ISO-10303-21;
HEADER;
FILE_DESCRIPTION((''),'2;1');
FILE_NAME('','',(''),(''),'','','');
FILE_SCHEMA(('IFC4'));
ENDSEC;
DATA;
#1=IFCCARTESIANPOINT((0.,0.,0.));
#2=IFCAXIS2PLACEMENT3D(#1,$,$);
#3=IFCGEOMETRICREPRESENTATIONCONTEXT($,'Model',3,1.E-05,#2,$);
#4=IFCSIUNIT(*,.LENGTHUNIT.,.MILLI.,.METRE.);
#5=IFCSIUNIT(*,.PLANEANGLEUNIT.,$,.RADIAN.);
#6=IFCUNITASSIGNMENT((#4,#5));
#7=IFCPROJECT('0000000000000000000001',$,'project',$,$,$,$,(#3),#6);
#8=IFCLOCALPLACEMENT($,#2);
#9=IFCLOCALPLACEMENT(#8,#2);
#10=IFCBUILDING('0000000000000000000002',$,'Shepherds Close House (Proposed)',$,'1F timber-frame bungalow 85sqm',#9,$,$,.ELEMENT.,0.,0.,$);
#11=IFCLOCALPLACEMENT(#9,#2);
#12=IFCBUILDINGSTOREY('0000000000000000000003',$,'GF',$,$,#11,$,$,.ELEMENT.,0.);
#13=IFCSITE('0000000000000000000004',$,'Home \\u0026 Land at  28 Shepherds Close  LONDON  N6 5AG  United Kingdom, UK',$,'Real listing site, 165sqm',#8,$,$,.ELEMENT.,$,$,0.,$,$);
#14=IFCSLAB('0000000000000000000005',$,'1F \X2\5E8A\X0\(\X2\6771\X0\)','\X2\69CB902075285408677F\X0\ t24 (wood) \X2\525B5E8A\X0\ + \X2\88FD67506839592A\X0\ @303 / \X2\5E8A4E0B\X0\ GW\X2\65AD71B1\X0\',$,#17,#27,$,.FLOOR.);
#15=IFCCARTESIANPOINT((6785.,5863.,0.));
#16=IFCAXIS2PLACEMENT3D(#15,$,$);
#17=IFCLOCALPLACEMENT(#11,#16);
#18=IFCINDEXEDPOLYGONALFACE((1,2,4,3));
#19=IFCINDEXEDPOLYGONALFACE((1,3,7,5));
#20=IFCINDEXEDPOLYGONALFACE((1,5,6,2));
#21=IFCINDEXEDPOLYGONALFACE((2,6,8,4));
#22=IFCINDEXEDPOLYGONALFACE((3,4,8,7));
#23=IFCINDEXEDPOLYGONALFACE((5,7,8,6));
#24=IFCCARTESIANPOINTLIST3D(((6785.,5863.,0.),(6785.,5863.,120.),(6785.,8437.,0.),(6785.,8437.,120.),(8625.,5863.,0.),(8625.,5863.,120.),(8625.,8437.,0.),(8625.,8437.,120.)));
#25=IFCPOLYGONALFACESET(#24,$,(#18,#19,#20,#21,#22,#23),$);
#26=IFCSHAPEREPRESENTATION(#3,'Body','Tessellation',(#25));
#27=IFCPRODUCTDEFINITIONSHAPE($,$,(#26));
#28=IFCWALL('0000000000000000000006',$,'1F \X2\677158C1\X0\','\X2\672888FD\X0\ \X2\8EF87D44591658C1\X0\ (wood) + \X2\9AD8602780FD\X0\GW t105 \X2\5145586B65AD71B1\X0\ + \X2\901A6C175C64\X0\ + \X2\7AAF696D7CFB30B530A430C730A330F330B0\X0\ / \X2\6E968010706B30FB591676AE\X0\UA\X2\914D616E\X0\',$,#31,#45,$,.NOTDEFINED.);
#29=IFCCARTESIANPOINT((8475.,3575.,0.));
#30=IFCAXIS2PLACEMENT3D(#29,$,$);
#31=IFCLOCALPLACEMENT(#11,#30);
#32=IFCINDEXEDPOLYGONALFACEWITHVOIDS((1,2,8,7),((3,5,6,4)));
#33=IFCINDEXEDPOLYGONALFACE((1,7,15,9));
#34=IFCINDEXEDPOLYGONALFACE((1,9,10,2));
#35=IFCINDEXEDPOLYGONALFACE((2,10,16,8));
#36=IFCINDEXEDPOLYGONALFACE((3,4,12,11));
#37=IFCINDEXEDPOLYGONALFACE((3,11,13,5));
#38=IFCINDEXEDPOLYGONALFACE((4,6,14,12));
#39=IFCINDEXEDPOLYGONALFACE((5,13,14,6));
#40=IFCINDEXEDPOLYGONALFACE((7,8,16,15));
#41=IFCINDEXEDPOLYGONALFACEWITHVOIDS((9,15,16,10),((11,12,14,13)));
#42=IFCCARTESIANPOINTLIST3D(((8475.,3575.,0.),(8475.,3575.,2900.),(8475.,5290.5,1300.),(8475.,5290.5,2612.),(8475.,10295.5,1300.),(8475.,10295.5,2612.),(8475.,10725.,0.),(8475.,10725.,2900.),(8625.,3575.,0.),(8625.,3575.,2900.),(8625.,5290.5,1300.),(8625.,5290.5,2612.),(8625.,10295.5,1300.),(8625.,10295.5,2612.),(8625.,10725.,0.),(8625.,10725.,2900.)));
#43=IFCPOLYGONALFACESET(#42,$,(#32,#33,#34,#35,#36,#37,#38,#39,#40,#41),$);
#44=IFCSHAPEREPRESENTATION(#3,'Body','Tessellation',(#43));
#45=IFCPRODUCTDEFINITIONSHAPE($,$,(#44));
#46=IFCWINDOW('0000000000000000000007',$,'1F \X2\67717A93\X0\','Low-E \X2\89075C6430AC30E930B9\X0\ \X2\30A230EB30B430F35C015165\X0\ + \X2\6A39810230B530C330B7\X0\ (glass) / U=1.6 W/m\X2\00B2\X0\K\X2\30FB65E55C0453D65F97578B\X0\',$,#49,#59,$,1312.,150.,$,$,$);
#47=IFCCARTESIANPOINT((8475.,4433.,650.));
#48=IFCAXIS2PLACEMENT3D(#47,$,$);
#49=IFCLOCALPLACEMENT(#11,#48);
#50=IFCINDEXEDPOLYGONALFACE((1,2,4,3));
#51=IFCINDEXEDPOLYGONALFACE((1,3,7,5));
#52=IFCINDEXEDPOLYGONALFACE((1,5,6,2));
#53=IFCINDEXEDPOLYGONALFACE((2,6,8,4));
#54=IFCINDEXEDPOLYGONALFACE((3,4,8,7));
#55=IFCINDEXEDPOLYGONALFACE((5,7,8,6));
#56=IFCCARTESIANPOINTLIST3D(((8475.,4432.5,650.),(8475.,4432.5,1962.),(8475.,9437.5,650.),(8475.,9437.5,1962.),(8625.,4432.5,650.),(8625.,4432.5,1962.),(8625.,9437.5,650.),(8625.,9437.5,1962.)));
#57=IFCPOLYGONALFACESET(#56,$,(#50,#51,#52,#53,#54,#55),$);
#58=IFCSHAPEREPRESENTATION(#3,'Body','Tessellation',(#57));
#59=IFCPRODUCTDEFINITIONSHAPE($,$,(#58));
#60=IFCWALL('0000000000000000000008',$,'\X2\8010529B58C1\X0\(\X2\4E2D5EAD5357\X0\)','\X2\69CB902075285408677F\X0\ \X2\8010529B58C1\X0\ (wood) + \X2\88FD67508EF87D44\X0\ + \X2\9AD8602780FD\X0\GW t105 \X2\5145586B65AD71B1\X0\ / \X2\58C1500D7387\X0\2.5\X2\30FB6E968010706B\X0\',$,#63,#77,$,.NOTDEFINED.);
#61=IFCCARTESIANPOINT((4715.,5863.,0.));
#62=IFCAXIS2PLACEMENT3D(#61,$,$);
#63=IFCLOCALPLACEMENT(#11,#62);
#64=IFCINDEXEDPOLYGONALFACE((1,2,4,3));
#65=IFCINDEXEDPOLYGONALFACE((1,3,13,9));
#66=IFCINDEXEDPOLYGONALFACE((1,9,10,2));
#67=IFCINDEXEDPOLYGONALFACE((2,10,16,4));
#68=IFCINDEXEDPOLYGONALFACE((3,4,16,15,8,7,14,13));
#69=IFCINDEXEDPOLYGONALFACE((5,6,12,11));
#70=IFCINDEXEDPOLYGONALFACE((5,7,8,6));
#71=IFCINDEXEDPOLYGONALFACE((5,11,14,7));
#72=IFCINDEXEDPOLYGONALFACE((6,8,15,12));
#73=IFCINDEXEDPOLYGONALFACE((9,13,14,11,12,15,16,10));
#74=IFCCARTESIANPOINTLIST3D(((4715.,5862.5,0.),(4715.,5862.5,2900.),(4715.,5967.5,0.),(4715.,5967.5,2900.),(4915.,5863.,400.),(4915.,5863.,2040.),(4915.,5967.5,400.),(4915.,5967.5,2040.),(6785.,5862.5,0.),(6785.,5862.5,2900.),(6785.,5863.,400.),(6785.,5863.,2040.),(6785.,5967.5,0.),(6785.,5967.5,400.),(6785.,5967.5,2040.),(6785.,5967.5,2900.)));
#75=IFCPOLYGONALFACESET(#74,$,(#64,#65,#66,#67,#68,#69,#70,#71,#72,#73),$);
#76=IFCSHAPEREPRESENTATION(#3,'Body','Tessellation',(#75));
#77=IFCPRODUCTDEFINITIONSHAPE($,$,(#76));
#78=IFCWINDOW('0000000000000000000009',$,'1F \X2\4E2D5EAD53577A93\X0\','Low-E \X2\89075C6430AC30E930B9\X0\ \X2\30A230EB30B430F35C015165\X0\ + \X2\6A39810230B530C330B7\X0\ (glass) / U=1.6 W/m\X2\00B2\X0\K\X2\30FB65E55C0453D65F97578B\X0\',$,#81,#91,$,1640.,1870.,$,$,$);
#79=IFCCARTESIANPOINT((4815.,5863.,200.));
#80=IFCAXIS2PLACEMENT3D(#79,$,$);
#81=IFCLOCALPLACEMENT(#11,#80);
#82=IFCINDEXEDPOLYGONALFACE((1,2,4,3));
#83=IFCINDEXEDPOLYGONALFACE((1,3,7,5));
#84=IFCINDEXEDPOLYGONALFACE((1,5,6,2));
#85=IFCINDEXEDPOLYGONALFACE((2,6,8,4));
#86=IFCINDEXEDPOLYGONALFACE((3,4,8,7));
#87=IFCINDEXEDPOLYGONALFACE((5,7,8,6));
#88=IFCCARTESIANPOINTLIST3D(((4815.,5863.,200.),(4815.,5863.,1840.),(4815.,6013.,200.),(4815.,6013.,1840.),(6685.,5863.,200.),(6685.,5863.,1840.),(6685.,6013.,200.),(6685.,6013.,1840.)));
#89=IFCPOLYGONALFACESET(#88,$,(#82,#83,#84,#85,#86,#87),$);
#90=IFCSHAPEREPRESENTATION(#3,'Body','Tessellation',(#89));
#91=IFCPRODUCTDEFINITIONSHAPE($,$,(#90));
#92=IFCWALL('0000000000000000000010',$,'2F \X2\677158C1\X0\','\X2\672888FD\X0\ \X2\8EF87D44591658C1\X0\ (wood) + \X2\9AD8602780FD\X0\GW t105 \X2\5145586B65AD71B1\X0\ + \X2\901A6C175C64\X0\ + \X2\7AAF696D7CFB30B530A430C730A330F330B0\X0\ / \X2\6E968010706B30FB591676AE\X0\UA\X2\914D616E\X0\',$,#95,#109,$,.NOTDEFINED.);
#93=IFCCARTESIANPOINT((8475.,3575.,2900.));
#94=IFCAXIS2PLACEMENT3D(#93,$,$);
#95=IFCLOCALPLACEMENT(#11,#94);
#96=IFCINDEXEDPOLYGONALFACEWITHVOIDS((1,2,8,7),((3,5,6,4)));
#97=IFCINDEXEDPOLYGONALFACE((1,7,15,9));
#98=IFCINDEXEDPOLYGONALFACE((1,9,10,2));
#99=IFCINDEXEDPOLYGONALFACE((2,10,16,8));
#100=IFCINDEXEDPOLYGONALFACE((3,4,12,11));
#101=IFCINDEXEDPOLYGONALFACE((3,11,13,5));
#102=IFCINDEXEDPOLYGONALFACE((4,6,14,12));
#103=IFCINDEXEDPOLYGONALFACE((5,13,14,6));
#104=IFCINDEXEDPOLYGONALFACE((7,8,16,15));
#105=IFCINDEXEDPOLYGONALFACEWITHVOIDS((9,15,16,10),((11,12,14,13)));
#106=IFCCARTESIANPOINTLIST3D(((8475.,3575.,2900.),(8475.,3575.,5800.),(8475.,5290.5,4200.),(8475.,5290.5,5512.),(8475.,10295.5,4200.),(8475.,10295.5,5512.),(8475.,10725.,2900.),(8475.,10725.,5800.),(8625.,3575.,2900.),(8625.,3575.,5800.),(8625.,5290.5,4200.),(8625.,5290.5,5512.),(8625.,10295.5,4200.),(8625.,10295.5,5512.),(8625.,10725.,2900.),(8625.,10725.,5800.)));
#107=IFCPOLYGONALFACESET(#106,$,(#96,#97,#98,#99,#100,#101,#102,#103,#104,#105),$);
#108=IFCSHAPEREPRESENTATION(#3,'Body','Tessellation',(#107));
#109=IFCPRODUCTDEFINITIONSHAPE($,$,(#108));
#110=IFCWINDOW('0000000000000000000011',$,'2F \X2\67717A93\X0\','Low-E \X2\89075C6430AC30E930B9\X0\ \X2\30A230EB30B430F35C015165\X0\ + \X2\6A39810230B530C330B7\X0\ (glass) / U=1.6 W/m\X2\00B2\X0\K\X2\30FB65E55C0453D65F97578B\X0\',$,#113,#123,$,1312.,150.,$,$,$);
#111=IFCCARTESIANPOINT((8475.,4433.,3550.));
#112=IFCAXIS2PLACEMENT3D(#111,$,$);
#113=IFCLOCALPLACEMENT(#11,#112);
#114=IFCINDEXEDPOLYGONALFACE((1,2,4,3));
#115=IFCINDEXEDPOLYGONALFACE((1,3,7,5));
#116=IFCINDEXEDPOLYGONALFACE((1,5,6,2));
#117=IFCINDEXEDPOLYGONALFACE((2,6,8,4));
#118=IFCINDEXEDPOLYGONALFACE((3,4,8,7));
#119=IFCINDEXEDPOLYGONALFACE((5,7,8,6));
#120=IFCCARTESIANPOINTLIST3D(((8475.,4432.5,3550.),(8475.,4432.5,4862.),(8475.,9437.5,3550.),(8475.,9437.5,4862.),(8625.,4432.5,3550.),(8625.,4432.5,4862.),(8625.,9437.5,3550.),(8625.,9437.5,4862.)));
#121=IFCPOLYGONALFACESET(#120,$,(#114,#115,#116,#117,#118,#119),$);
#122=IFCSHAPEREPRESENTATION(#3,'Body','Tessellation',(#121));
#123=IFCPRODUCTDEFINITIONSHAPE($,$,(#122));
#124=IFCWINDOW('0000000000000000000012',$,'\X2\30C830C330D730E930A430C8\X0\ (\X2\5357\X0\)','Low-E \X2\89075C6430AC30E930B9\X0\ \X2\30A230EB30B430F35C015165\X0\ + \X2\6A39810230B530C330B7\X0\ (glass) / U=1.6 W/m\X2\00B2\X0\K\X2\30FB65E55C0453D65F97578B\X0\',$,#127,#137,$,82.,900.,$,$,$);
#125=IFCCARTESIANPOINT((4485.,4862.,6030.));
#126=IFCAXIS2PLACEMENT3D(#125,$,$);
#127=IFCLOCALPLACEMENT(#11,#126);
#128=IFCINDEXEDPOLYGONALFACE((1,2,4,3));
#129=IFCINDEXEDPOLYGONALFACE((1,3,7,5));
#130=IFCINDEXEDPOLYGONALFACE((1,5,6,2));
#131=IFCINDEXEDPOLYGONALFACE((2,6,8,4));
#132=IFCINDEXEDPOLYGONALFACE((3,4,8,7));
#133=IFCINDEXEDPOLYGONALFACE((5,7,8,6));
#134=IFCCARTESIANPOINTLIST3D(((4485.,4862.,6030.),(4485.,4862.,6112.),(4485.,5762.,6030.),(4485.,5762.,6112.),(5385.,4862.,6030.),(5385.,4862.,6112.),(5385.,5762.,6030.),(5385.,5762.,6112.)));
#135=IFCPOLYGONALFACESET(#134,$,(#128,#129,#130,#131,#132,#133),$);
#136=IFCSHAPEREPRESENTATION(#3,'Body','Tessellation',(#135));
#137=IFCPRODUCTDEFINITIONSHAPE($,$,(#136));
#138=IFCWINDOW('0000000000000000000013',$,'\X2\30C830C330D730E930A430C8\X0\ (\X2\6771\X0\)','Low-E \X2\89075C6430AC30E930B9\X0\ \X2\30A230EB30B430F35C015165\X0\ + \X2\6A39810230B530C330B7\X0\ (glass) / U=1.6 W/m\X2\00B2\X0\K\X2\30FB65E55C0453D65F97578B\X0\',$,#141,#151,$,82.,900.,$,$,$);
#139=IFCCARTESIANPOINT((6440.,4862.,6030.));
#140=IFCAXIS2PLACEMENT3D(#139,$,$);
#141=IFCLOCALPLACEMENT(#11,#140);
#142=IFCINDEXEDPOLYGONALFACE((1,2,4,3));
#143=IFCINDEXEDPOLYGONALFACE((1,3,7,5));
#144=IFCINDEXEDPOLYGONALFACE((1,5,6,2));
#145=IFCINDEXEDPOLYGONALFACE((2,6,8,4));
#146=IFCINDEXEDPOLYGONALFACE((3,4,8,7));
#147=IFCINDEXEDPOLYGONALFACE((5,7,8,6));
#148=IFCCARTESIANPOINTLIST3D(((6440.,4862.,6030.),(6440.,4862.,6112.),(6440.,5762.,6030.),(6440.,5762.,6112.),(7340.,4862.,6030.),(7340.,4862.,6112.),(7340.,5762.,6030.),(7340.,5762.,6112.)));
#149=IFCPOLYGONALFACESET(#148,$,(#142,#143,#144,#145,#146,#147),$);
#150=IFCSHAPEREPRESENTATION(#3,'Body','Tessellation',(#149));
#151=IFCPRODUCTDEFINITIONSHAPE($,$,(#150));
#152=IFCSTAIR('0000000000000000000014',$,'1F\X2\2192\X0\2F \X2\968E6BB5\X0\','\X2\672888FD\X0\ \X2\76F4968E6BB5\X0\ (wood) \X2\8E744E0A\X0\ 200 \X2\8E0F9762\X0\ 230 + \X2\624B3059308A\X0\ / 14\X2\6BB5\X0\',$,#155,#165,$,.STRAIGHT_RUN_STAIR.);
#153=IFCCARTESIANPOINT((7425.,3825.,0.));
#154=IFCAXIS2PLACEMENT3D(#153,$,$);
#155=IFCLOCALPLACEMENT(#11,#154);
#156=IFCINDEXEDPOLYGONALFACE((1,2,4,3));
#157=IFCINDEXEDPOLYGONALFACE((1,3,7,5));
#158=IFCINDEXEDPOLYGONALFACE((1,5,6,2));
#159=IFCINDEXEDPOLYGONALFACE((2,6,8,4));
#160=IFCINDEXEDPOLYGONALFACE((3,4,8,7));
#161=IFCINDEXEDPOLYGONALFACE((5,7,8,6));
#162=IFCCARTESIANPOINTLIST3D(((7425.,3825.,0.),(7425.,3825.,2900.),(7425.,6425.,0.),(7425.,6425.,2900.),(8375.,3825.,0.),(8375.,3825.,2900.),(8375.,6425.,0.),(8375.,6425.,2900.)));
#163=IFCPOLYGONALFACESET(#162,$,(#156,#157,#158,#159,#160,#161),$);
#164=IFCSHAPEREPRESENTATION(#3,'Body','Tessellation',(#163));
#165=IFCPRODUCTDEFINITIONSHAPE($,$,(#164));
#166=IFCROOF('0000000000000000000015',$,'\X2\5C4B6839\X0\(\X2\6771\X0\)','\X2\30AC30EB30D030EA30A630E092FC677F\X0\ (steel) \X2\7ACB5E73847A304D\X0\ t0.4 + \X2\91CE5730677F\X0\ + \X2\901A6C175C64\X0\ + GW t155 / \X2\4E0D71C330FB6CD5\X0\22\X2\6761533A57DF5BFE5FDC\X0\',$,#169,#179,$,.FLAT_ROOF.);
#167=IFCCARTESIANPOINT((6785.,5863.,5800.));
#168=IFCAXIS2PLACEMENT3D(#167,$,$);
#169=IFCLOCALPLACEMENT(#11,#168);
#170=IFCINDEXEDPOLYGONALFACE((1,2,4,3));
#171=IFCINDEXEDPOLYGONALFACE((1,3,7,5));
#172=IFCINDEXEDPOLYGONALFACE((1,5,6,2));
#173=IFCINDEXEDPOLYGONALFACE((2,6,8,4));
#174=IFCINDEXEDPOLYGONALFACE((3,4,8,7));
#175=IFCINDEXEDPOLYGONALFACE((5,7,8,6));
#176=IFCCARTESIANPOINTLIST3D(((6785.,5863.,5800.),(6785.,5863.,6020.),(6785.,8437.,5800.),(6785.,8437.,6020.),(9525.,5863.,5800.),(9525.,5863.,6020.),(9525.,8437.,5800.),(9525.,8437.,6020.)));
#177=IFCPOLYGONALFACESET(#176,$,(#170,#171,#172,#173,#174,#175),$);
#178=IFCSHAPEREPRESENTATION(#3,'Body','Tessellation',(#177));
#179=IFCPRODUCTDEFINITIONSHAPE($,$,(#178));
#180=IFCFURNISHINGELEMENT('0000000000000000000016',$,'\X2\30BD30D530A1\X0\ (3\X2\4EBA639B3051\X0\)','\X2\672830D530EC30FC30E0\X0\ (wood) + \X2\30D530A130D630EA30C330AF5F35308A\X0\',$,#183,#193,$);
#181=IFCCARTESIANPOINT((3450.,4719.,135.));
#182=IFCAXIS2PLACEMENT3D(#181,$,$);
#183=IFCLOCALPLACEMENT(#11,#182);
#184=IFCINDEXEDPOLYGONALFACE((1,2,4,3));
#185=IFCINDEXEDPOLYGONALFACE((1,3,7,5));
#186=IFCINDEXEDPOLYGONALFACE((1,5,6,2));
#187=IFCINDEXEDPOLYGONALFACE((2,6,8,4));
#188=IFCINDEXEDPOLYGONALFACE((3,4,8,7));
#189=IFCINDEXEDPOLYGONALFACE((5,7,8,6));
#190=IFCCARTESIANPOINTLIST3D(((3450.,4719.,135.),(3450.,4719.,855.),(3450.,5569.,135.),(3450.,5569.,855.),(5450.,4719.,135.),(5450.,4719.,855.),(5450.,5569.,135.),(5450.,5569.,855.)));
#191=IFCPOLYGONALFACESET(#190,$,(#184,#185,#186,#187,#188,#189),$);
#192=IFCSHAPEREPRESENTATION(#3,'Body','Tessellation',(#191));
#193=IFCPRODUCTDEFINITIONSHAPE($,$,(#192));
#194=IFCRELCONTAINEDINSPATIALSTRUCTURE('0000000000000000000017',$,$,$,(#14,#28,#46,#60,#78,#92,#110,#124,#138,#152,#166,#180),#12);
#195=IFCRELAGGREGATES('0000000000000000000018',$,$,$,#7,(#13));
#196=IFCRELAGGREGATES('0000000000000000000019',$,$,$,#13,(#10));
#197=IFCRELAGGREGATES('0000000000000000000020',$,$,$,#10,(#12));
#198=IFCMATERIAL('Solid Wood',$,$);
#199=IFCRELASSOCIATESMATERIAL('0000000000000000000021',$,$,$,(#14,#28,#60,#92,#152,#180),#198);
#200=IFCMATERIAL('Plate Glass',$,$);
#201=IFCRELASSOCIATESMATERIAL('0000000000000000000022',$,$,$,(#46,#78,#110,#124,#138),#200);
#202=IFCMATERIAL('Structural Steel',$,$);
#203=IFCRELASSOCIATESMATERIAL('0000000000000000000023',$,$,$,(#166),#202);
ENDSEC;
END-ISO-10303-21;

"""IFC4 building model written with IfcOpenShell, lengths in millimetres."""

from ifc_helpers import new_model, si_unit, frame, frame_2d, origin, place, context, project, spatial, rectangle, extrude, material, element, fill, save


model = new_model("IFC4")

# Units and contexts
model_context = context("Model", 3, precision=1e-05, world=origin())
ifc_project = project(units=[si_unit("LENGTHUNIT", "METRE", prefix="MILLI"), si_unit("PLANEANGLEUNIT", "RADIAN")], contexts=[model_context])

# Site, building, storey
site_placement = place(None, origin())
site = spatial("IfcSite", under=ifc_project, at=site_placement, Name="Home \\u0026 Land at  28 Shepherds Close  LONDON  N6 5AG  United Kingdom, UK", ObjectType="Real listing site, 165sqm", CompositionType="ELEMENT", RefElevation=0.0)
building_placement = place(site_placement, origin())
building = spatial("IfcBuilding", under=site, at=building_placement, Name="Shepherds Close House (Proposed)", ObjectType="1F timber-frame bungalow 85sqm", CompositionType="ELEMENT", ElevationOfRefHeight=0.0, ElevationOfTerrain=0.0)
storey_placement = place(building_placement, origin())
storey = spatial("IfcBuildingStorey", under=building, at=storey_placement, Name="GF", CompositionType="ELEMENT", Elevation=0.0)

# Slab
ifc_material_1 = material(Name="Solid Wood")
slab_placement = place(storey_placement, frame((6785.0, 5863.0, 0.0)))
element("IfcSlab", 1, at=slab_placement, inside=storey, material=ifc_material_1, Name="1F 床(東)", Description="構造用合板 t24 (wood) 剛床 + 製材根太 @303 / 床下 GW断熱", PredefinedType="FLOOR", context=model_context, shape_type="SweptSolid", body=[
    extrude(rectangle(XDim=1840.0, YDim=2574.0, at=frame_2d((920.0, 1287.0))), frame((6785.0, 5863.0, 0.0)), (0.0, 0.0, 1.0), 120.0),
])

# Walls, openings, windows
wall_1_placement = place(storey_placement, frame((8475.0, 3575.0, 0.0)))
wall_1 = element("IfcWall", 2, at=wall_1_placement, inside=storey, material=ifc_material_1, Name="1F 東壁", Description="木製 軸組外壁 (wood) + 高性能GW t105 充填断熱 + 通気層 + 窯業系サイディング / 準耐火・外皮UA配慮", PredefinedType="NOTDEFINED", context=model_context, shape_type="SweptSolid", body=[
    extrude(rectangle(XDim=150.0, YDim=7150.0, at=frame_2d((75.0, 3575.0))), frame((8475.0, 3575.0, 0.0)), (0.0, 0.0, 1.0), 2900.0),
])
opening_1_placement = place(storey_placement, frame((8475.0, 4433.0, 650.0)))
opening_1 = element("IfcOpeningElement", 3, at=opening_1_placement, cuts=wall_1, PredefinedType="NOTDEFINED", context=model_context, shape_type="SweptSolid", body=[
    extrude(rectangle(XDim=150.0, YDim=5005.0, at=frame_2d((75.0, 2502.0))), frame((8475.0, 4433.0, 650.0)), (0.0, 0.0, 1.0), 1312.0),
])
ifc_material_2 = material(Name="Plate Glass")
window_1_placement = place(storey_placement, frame((8475.0, 4433.0, 650.0)))
window_1 = element("IfcWindow", 4, at=window_1_placement, inside=storey, material=ifc_material_2, Name="1F 東窓", Description="Low-E 複層ガラス アルゴン封入 + 樹脂サッシ (glass) / U=1.6 W/m²K・日射取得型", OverallHeight=1312.0, OverallWidth=150.0, context=model_context, shape_type="SweptSolid", body=[
    extrude(rectangle(XDim=150.0, YDim=5005.0, at=frame_2d((75.0, 2502.0))), frame((8475.0, 4433.0, 650.0)), (0.0, 0.0, 1.0), 1312.0),
])
fill(opening_1, window_1)
wall_2_placement = place(storey_placement, frame((4715.0, 5863.0, 0.0)))
wall_2 = element("IfcWall", 5, at=wall_2_placement, inside=storey, material=ifc_material_1, Name="耐力壁(中庭南)", Description="構造用合板 耐力壁 (wood) + 製材軸組 + 高性能GW t105 充填断熱 / 壁倍率2.5・準耐火", PredefinedType="NOTDEFINED", context=model_context, shape_type="SweptSolid", body=[
    extrude(rectangle(XDim=2070.0, YDim=105.0, at=frame_2d((1035.0, 52.0))), frame((4715.0, 5863.0, 0.0)), (0.0, 0.0, 1.0), 2900.0),
])
opening_2_placement = place(storey_placement, frame((4815.0, 5863.0, 200.0)))
opening_2 = element("IfcOpeningElement", 6, at=opening_2_placement, cuts=wall_2, PredefinedType="NOTDEFINED", context=model_context, shape_type="SweptSolid", body=[
    extrude(rectangle(XDim=1870.0, YDim=150.0, at=frame_2d((935.0, 75.0))), frame((4815.0, 5863.0, 200.0)), (0.0, 0.0, 1.0), 1640.0),
])
window_2_placement = place(storey_placement, frame((4815.0, 5863.0, 200.0)))
window_2 = element("IfcWindow", 7, at=window_2_placement, inside=storey, material=ifc_material_2, Name="1F 中庭南窓", Description="Low-E 複層ガラス アルゴン封入 + 樹脂サッシ (glass) / U=1.6 W/m²K・日射取得型", OverallHeight=1640.0, OverallWidth=1870.0, context=model_context, shape_type="SweptSolid", body=[
    extrude(rectangle(XDim=1870.0, YDim=150.0, at=frame_2d((935.0, 75.0))), frame((4815.0, 5863.0, 200.0)), (0.0, 0.0, 1.0), 1640.0),
])
fill(opening_2, window_2)

# Wall, opening, window
wall_3_placement = place(storey_placement, frame((8475.0, 3575.0, 2900.0)))
wall_3 = element("IfcWall", 8, at=wall_3_placement, inside=storey, material=ifc_material_1, Name="2F 東壁", Description="木製 軸組外壁 (wood) + 高性能GW t105 充填断熱 + 通気層 + 窯業系サイディング / 準耐火・外皮UA配慮", PredefinedType="NOTDEFINED", context=model_context, shape_type="SweptSolid", body=[
    extrude(rectangle(XDim=150.0, YDim=7150.0, at=frame_2d((75.0, 3575.0))), frame((8475.0, 3575.0, 2900.0)), (0.0, 0.0, 1.0), 2900.0),
])
opening_3_placement = place(storey_placement, frame((8475.0, 4433.0, 3550.0)))
opening_3 = element("IfcOpeningElement", 9, at=opening_3_placement, cuts=wall_3, PredefinedType="NOTDEFINED", context=model_context, shape_type="SweptSolid", body=[
    extrude(rectangle(XDim=150.0, YDim=5005.0, at=frame_2d((75.0, 2502.0))), frame((8475.0, 4433.0, 3550.0)), (0.0, 0.0, 1.0), 1312.0),
])
window_3_placement = place(storey_placement, frame((8475.0, 4433.0, 3550.0)))
window_3 = element("IfcWindow", 10, at=window_3_placement, inside=storey, material=ifc_material_2, Name="2F 東窓", Description="Low-E 複層ガラス アルゴン封入 + 樹脂サッシ (glass) / U=1.6 W/m²K・日射取得型", OverallHeight=1312.0, OverallWidth=150.0, context=model_context, shape_type="SweptSolid", body=[
    extrude(rectangle(XDim=150.0, YDim=5005.0, at=frame_2d((75.0, 2502.0))), frame((8475.0, 4433.0, 3550.0)), (0.0, 0.0, 1.0), 1312.0),
])
fill(opening_3, window_3)

# Windows
window_4_placement = place(storey_placement, frame((4485.0, 4862.0, 6030.0)))
element("IfcWindow", 11, at=window_4_placement, inside=storey, material=ifc_material_2, Name="トップライト (南)", Description="Low-E 複層ガラス アルゴン封入 + 樹脂サッシ (glass) / U=1.6 W/m²K・日射取得型", OverallHeight=82.0, OverallWidth=900.0, context=model_context, shape_type="SweptSolid", body=[
    extrude(rectangle(XDim=900.0, YDim=900.0, at=frame_2d((450.0, 450.0))), frame((4485.0, 4862.0, 6030.0)), (0.0, 0.0, 1.0), 82.0),
])
window_5_placement = place(storey_placement, frame((6440.0, 4862.0, 6030.0)))
element("IfcWindow", 12, at=window_5_placement, inside=storey, material=ifc_material_2, Name="トップライト (東)", Description="Low-E 複層ガラス アルゴン封入 + 樹脂サッシ (glass) / U=1.6 W/m²K・日射取得型", OverallHeight=82.0, OverallWidth=900.0, context=model_context, shape_type="SweptSolid", body=[
    extrude(rectangle(XDim=900.0, YDim=900.0, at=frame_2d((450.0, 450.0))), frame((6440.0, 4862.0, 6030.0)), (0.0, 0.0, 1.0), 82.0),
])

# Stair
stair_placement = place(storey_placement, frame((7425.0, 3825.0, 0.0)))
element("IfcStair", 13, at=stair_placement, inside=storey, material=ifc_material_1, Name="1F→2F 階段", Description="木製 直階段 (wood) 蹴上 200 踏面 230 + 手すり / 14段", PredefinedType="STRAIGHT_RUN_STAIR", context=model_context, shape_type="SweptSolid", body=[
    extrude(rectangle(XDim=950.0, YDim=2600.0, at=frame_2d((475.0, 1300.0))), frame((7425.0, 3825.0, 0.0)), (0.0, 0.0, 1.0), 2900.0),
])

# Roof
ifc_material_3 = material(Name="Structural Steel")
roof_placement = place(storey_placement, frame((6785.0, 5863.0, 5800.0)))
element("IfcRoof", 14, at=roof_placement, inside=storey, material=ifc_material_3, Name="屋根(東)", Description="ガルバリウム鋼板 (steel) 立平葺き t0.4 + 野地板 + 通気層 + GW t155 / 不燃・法22条区域対応", PredefinedType="FLAT_ROOF", context=model_context, shape_type="SweptSolid", body=[
    extrude(rectangle(XDim=2740.0, YDim=2574.0, at=frame_2d((1370.0, 1287.0))), frame((6785.0, 5863.0, 5800.0)), (0.0, 0.0, 1.0), 220.0),
])

# Furnishing element
furnishing_1_placement = place(storey_placement, frame((3450.0, 4719.0, 135.0)))
element("IfcFurnishingElement", 15, at=furnishing_1_placement, inside=storey, material=ifc_material_1, Name="ソファ (3人掛け)", Description="木フレーム (wood) + ファブリック張り", context=model_context, shape_type="SweptSolid", body=[
    extrude(rectangle(XDim=2000.0, YDim=850.0, at=frame_2d((1000.0, 425.0))), frame((3450.0, 4719.0, 135.0)), (0.0, 0.0, 1.0), 720.0),
])

save(model, "model.ifc")
